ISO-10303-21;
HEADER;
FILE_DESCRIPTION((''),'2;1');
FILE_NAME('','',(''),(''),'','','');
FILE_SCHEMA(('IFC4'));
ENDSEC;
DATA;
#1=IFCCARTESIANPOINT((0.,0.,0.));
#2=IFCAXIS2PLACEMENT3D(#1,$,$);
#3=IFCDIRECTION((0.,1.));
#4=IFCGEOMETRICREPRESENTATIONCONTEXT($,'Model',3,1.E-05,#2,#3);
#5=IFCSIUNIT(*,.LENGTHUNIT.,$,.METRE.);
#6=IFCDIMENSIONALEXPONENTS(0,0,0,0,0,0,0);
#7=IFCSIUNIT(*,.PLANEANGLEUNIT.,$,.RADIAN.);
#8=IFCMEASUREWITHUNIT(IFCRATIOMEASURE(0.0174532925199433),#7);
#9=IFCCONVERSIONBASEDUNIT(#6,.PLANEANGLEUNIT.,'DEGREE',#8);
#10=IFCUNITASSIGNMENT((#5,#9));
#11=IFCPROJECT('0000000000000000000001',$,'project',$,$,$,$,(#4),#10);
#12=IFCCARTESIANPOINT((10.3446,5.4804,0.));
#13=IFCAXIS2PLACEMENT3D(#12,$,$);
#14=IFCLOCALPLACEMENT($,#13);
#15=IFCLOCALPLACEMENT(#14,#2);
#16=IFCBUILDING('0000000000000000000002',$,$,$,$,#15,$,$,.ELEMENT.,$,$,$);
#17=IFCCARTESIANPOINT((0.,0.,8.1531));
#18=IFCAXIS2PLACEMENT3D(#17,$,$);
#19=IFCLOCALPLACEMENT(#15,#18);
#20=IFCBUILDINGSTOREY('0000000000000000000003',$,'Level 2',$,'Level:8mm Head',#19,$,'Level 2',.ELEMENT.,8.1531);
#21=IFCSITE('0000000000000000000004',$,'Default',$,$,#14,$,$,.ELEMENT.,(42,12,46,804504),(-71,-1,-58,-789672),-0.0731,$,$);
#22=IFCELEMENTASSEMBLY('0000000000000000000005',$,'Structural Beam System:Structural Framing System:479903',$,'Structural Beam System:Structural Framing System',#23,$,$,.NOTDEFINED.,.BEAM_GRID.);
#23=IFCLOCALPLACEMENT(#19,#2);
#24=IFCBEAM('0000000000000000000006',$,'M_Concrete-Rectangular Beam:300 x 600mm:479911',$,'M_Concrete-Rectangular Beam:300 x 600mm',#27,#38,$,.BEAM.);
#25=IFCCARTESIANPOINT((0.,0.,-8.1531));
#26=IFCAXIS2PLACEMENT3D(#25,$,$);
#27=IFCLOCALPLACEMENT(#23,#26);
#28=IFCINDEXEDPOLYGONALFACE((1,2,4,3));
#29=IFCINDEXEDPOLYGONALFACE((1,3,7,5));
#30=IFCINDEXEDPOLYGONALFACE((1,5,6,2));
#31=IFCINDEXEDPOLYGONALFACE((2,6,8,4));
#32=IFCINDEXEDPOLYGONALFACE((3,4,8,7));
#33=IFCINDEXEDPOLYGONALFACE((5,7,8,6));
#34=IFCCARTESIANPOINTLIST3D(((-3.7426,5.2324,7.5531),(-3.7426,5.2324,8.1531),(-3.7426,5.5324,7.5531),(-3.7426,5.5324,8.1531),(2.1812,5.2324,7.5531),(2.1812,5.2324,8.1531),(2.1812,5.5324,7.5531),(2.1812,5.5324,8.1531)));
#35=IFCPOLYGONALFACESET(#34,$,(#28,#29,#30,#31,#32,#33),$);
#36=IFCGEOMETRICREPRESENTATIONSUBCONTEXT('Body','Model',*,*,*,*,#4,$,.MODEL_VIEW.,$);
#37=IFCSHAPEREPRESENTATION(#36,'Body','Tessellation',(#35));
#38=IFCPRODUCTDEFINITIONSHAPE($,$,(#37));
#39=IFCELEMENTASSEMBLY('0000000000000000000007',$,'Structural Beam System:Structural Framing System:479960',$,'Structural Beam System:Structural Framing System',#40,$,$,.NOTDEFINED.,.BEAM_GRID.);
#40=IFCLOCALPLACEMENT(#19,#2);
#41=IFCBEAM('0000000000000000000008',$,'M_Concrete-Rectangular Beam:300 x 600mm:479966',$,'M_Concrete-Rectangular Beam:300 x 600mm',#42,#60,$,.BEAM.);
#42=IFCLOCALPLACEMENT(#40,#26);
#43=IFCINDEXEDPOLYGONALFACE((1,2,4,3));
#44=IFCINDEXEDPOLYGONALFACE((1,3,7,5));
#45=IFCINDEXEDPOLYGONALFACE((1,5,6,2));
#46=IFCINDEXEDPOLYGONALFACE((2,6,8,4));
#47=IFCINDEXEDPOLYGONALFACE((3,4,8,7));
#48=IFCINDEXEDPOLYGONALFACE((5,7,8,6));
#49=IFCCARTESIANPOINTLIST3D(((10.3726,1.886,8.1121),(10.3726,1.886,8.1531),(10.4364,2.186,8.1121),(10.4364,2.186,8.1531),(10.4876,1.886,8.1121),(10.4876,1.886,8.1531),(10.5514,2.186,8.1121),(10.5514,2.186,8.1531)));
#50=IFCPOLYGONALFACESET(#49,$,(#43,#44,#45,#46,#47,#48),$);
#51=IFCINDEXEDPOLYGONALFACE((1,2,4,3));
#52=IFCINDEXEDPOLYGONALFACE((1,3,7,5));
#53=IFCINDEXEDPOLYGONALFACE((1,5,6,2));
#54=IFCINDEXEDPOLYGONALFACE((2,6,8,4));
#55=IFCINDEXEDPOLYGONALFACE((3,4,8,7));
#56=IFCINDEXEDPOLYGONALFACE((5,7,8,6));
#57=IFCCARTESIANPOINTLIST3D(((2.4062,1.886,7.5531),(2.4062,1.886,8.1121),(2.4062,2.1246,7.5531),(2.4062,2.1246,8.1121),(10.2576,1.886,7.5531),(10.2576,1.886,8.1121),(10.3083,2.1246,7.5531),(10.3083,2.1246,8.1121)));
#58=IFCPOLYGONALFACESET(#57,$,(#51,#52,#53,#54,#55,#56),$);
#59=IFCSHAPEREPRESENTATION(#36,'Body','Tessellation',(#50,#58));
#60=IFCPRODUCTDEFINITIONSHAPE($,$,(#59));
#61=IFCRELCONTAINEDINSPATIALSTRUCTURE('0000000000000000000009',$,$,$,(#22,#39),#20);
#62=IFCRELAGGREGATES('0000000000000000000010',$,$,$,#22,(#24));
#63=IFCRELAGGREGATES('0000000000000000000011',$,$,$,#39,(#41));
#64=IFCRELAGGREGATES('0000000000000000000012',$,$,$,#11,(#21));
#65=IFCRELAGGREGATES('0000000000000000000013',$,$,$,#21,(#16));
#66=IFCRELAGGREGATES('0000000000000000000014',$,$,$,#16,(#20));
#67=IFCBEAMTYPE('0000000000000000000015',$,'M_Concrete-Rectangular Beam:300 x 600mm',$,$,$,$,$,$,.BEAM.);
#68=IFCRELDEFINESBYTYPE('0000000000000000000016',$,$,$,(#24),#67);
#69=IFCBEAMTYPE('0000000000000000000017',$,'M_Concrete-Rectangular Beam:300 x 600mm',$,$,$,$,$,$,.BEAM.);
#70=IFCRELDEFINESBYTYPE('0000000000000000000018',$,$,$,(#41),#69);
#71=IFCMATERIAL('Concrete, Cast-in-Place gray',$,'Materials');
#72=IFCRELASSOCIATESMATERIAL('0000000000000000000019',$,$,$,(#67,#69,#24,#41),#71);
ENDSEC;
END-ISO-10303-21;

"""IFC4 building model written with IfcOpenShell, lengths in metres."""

from ifc_helpers import new_model, entity, si_unit, converted_unit, direction, frame, frame_2d, origin, place, context, subcontext, project, spatial, rectangle, extrude, clip, halfspace, source, transform, mapped, material, material_profile, profile_set, profile_usage, type_object, type_shapes, element, aggregate, save


model = new_model("IFC4")

# Units and contexts
model_context = context("Model", 3, precision=1e-05, world=origin(), true_north=direction((0.0, 1.0)))
body_context = subcontext(model_context, "Body", "Model", "MODEL_VIEW")
ifc_project = project(units=[si_unit("LENGTHUNIT", "METRE"), converted_unit("PLANEANGLEUNIT", "DEGREE", entity("IfcRatioMeasure", 0.0174532925199433), si_unit("PLANEANGLEUNIT", "RADIAN"), dimensions=[0, 0, 0, 0, 0, 0, 0])], contexts=[model_context])

# Site, building, storey
site_placement = place(None, frame((10.3446, 5.4804, 0.0)))
site = spatial("IfcSite", under=ifc_project, at=site_placement, Name="Default", CompositionType="ELEMENT", RefLatitude=(42, 12, 46, 804504), RefLongitude=(-71, -1, -58, -789672), RefElevation=-0.0731)
building_placement = place(site_placement, origin())
building = spatial("IfcBuilding", under=site, at=building_placement, CompositionType="ELEMENT")
storey_placement = place(building_placement, frame((0.0, 0.0, 8.1531)))
storey = spatial("IfcBuildingStorey", under=building, at=storey_placement, Name="Level 2", ObjectType="Level:8mm Head", LongName="Level 2", CompositionType="ELEMENT", Elevation=8.1531)

# Element assembly, beam
ifc_material_1 = material(Name="Concrete, Cast-in-Place gray", Category="Materials")
ifc_material_profile = material_profile(ifc_material_1, rectangle(XDim=0.559, YDim=0.3, at=frame_2d((0.0, 0.0), x_axis=(1.0, 0.0))), Name="300 x 600mm")
ifc_profile_set = profile_set([ifc_material_profile], Name="300 x 600mm")
assembly_1_placement = place(storey_placement, origin())
assembly_1 = element("IfcElementAssembly", 1, at=assembly_1_placement, inside=storey, Name="Structural Beam System:Structural Framing System:479903", ObjectType="Structural Beam System:Structural Framing System", AssemblyPlace="NOTDEFINED", PredefinedType="BEAM_GRID")
ifc_profile_usage_1 = profile_usage(ifc_profile_set, cardinal=8)
beam_type_1 = type_object("IfcBeamType", Name="M_Concrete-Rectangular Beam:300 x 600mm", PredefinedType="BEAM", material=ifc_profile_set)
shared_shape_1 = source(origin(), body_context, "Body", "SweptSolid", [
    extrude(rectangle(XDim=0.6, YDim=0.3, at=frame_2d((0.0, 0.0), x_axis=(1.0, 0.0))), frame((-3.7426, 5.3824, 7.8531), z_axis=(1.0, 0.0, 0.0), x_axis=(0.0, 0.0, -1.0)), (0.0, 0.0, 1.0), 5.9238),
])
type_shapes(beam_type_1, [shared_shape_1])
beam_1_placement = place(assembly_1_placement, frame((0.0, 0.0, -8.1531)))
beam_1 = element("IfcBeam", 2, at=beam_1_placement, type_object=beam_type_1, material=ifc_profile_usage_1, Name="M_Concrete-Rectangular Beam:300 x 600mm:479911", ObjectType="M_Concrete-Rectangular Beam:300 x 600mm", PredefinedType="BEAM", context=body_context, shape_type="MappedRepresentation", body=[
    mapped(shared_shape_1, transform((0.0, 0.0, 0.0), scale=1.0)),
])
aggregate(assembly_1, [beam_1])

# Element assembly, beam
assembly_2_placement = place(storey_placement, origin())
assembly_2 = element("IfcElementAssembly", 3, at=assembly_2_placement, inside=storey, Name="Structural Beam System:Structural Framing System:479960", ObjectType="Structural Beam System:Structural Framing System", AssemblyPlace="NOTDEFINED", PredefinedType="BEAM_GRID")
ifc_profile_usage_2 = profile_usage(ifc_profile_set, cardinal=8)
beam_type_2 = type_object("IfcBeamType", Name="M_Concrete-Rectangular Beam:300 x 600mm", PredefinedType="BEAM", material=ifc_profile_set)
shared_shape_2 = source(origin(), body_context, "Body", "Clipping", [
    clip(clip(extrude(rectangle(XDim=0.041, YDim=0.3, at=frame_2d((0.0, 0.0), x_axis=(1.0, 0.0))), frame((10.3726, 2.036, 8.1326), z_axis=(1.0, 0.0, 0.0), x_axis=(0.0, 0.0, -1.0)), (0.0, 0.0, 1.0), 0.1788), halfspace(frame((10.4473, 2.2371, 8.1121), z_axis=(-0.978148, 0.207912, 0.0), x_axis=(0.0, 0.0, 1.0)), False)), halfspace(frame((10.476, 1.8311, 8.5239), z_axis=(0.978148, -0.207912, 0.0), x_axis=(0.207912, 0.978148, 0.0)), False)),
    clip(extrude(rectangle(XDim=0.559, YDim=0.2387, at=frame_2d((0.0, 0.0), x_axis=(1.0, 0.0))), frame((2.4062, 2.0053, 7.8326), z_axis=(1.0, 0.0, 0.0), x_axis=(0.0, 0.0, -1.0)), (0.0, 0.0, 1.0), 7.9022), halfspace(frame((8.6968, -5.457, 4.5531), z_axis=(0.978148, -0.207912, 0.0), x_axis=(-0.207912, -0.978148, 0.0)), False)),
])
type_shapes(beam_type_2, [shared_shape_2])
beam_2_placement = place(assembly_2_placement, frame((0.0, 0.0, -8.1531)))
beam_2 = element("IfcBeam", 4, at=beam_2_placement, type_object=beam_type_2, material=ifc_profile_usage_2, Name="M_Concrete-Rectangular Beam:300 x 600mm:479966", ObjectType="M_Concrete-Rectangular Beam:300 x 600mm", PredefinedType="BEAM", context=body_context, shape_type="MappedRepresentation", body=[
    mapped(shared_shape_2, transform((0.0, 0.0, 0.0), scale=1.0)),
])
aggregate(assembly_2, [beam_2])

save(model, "model.ifc")
